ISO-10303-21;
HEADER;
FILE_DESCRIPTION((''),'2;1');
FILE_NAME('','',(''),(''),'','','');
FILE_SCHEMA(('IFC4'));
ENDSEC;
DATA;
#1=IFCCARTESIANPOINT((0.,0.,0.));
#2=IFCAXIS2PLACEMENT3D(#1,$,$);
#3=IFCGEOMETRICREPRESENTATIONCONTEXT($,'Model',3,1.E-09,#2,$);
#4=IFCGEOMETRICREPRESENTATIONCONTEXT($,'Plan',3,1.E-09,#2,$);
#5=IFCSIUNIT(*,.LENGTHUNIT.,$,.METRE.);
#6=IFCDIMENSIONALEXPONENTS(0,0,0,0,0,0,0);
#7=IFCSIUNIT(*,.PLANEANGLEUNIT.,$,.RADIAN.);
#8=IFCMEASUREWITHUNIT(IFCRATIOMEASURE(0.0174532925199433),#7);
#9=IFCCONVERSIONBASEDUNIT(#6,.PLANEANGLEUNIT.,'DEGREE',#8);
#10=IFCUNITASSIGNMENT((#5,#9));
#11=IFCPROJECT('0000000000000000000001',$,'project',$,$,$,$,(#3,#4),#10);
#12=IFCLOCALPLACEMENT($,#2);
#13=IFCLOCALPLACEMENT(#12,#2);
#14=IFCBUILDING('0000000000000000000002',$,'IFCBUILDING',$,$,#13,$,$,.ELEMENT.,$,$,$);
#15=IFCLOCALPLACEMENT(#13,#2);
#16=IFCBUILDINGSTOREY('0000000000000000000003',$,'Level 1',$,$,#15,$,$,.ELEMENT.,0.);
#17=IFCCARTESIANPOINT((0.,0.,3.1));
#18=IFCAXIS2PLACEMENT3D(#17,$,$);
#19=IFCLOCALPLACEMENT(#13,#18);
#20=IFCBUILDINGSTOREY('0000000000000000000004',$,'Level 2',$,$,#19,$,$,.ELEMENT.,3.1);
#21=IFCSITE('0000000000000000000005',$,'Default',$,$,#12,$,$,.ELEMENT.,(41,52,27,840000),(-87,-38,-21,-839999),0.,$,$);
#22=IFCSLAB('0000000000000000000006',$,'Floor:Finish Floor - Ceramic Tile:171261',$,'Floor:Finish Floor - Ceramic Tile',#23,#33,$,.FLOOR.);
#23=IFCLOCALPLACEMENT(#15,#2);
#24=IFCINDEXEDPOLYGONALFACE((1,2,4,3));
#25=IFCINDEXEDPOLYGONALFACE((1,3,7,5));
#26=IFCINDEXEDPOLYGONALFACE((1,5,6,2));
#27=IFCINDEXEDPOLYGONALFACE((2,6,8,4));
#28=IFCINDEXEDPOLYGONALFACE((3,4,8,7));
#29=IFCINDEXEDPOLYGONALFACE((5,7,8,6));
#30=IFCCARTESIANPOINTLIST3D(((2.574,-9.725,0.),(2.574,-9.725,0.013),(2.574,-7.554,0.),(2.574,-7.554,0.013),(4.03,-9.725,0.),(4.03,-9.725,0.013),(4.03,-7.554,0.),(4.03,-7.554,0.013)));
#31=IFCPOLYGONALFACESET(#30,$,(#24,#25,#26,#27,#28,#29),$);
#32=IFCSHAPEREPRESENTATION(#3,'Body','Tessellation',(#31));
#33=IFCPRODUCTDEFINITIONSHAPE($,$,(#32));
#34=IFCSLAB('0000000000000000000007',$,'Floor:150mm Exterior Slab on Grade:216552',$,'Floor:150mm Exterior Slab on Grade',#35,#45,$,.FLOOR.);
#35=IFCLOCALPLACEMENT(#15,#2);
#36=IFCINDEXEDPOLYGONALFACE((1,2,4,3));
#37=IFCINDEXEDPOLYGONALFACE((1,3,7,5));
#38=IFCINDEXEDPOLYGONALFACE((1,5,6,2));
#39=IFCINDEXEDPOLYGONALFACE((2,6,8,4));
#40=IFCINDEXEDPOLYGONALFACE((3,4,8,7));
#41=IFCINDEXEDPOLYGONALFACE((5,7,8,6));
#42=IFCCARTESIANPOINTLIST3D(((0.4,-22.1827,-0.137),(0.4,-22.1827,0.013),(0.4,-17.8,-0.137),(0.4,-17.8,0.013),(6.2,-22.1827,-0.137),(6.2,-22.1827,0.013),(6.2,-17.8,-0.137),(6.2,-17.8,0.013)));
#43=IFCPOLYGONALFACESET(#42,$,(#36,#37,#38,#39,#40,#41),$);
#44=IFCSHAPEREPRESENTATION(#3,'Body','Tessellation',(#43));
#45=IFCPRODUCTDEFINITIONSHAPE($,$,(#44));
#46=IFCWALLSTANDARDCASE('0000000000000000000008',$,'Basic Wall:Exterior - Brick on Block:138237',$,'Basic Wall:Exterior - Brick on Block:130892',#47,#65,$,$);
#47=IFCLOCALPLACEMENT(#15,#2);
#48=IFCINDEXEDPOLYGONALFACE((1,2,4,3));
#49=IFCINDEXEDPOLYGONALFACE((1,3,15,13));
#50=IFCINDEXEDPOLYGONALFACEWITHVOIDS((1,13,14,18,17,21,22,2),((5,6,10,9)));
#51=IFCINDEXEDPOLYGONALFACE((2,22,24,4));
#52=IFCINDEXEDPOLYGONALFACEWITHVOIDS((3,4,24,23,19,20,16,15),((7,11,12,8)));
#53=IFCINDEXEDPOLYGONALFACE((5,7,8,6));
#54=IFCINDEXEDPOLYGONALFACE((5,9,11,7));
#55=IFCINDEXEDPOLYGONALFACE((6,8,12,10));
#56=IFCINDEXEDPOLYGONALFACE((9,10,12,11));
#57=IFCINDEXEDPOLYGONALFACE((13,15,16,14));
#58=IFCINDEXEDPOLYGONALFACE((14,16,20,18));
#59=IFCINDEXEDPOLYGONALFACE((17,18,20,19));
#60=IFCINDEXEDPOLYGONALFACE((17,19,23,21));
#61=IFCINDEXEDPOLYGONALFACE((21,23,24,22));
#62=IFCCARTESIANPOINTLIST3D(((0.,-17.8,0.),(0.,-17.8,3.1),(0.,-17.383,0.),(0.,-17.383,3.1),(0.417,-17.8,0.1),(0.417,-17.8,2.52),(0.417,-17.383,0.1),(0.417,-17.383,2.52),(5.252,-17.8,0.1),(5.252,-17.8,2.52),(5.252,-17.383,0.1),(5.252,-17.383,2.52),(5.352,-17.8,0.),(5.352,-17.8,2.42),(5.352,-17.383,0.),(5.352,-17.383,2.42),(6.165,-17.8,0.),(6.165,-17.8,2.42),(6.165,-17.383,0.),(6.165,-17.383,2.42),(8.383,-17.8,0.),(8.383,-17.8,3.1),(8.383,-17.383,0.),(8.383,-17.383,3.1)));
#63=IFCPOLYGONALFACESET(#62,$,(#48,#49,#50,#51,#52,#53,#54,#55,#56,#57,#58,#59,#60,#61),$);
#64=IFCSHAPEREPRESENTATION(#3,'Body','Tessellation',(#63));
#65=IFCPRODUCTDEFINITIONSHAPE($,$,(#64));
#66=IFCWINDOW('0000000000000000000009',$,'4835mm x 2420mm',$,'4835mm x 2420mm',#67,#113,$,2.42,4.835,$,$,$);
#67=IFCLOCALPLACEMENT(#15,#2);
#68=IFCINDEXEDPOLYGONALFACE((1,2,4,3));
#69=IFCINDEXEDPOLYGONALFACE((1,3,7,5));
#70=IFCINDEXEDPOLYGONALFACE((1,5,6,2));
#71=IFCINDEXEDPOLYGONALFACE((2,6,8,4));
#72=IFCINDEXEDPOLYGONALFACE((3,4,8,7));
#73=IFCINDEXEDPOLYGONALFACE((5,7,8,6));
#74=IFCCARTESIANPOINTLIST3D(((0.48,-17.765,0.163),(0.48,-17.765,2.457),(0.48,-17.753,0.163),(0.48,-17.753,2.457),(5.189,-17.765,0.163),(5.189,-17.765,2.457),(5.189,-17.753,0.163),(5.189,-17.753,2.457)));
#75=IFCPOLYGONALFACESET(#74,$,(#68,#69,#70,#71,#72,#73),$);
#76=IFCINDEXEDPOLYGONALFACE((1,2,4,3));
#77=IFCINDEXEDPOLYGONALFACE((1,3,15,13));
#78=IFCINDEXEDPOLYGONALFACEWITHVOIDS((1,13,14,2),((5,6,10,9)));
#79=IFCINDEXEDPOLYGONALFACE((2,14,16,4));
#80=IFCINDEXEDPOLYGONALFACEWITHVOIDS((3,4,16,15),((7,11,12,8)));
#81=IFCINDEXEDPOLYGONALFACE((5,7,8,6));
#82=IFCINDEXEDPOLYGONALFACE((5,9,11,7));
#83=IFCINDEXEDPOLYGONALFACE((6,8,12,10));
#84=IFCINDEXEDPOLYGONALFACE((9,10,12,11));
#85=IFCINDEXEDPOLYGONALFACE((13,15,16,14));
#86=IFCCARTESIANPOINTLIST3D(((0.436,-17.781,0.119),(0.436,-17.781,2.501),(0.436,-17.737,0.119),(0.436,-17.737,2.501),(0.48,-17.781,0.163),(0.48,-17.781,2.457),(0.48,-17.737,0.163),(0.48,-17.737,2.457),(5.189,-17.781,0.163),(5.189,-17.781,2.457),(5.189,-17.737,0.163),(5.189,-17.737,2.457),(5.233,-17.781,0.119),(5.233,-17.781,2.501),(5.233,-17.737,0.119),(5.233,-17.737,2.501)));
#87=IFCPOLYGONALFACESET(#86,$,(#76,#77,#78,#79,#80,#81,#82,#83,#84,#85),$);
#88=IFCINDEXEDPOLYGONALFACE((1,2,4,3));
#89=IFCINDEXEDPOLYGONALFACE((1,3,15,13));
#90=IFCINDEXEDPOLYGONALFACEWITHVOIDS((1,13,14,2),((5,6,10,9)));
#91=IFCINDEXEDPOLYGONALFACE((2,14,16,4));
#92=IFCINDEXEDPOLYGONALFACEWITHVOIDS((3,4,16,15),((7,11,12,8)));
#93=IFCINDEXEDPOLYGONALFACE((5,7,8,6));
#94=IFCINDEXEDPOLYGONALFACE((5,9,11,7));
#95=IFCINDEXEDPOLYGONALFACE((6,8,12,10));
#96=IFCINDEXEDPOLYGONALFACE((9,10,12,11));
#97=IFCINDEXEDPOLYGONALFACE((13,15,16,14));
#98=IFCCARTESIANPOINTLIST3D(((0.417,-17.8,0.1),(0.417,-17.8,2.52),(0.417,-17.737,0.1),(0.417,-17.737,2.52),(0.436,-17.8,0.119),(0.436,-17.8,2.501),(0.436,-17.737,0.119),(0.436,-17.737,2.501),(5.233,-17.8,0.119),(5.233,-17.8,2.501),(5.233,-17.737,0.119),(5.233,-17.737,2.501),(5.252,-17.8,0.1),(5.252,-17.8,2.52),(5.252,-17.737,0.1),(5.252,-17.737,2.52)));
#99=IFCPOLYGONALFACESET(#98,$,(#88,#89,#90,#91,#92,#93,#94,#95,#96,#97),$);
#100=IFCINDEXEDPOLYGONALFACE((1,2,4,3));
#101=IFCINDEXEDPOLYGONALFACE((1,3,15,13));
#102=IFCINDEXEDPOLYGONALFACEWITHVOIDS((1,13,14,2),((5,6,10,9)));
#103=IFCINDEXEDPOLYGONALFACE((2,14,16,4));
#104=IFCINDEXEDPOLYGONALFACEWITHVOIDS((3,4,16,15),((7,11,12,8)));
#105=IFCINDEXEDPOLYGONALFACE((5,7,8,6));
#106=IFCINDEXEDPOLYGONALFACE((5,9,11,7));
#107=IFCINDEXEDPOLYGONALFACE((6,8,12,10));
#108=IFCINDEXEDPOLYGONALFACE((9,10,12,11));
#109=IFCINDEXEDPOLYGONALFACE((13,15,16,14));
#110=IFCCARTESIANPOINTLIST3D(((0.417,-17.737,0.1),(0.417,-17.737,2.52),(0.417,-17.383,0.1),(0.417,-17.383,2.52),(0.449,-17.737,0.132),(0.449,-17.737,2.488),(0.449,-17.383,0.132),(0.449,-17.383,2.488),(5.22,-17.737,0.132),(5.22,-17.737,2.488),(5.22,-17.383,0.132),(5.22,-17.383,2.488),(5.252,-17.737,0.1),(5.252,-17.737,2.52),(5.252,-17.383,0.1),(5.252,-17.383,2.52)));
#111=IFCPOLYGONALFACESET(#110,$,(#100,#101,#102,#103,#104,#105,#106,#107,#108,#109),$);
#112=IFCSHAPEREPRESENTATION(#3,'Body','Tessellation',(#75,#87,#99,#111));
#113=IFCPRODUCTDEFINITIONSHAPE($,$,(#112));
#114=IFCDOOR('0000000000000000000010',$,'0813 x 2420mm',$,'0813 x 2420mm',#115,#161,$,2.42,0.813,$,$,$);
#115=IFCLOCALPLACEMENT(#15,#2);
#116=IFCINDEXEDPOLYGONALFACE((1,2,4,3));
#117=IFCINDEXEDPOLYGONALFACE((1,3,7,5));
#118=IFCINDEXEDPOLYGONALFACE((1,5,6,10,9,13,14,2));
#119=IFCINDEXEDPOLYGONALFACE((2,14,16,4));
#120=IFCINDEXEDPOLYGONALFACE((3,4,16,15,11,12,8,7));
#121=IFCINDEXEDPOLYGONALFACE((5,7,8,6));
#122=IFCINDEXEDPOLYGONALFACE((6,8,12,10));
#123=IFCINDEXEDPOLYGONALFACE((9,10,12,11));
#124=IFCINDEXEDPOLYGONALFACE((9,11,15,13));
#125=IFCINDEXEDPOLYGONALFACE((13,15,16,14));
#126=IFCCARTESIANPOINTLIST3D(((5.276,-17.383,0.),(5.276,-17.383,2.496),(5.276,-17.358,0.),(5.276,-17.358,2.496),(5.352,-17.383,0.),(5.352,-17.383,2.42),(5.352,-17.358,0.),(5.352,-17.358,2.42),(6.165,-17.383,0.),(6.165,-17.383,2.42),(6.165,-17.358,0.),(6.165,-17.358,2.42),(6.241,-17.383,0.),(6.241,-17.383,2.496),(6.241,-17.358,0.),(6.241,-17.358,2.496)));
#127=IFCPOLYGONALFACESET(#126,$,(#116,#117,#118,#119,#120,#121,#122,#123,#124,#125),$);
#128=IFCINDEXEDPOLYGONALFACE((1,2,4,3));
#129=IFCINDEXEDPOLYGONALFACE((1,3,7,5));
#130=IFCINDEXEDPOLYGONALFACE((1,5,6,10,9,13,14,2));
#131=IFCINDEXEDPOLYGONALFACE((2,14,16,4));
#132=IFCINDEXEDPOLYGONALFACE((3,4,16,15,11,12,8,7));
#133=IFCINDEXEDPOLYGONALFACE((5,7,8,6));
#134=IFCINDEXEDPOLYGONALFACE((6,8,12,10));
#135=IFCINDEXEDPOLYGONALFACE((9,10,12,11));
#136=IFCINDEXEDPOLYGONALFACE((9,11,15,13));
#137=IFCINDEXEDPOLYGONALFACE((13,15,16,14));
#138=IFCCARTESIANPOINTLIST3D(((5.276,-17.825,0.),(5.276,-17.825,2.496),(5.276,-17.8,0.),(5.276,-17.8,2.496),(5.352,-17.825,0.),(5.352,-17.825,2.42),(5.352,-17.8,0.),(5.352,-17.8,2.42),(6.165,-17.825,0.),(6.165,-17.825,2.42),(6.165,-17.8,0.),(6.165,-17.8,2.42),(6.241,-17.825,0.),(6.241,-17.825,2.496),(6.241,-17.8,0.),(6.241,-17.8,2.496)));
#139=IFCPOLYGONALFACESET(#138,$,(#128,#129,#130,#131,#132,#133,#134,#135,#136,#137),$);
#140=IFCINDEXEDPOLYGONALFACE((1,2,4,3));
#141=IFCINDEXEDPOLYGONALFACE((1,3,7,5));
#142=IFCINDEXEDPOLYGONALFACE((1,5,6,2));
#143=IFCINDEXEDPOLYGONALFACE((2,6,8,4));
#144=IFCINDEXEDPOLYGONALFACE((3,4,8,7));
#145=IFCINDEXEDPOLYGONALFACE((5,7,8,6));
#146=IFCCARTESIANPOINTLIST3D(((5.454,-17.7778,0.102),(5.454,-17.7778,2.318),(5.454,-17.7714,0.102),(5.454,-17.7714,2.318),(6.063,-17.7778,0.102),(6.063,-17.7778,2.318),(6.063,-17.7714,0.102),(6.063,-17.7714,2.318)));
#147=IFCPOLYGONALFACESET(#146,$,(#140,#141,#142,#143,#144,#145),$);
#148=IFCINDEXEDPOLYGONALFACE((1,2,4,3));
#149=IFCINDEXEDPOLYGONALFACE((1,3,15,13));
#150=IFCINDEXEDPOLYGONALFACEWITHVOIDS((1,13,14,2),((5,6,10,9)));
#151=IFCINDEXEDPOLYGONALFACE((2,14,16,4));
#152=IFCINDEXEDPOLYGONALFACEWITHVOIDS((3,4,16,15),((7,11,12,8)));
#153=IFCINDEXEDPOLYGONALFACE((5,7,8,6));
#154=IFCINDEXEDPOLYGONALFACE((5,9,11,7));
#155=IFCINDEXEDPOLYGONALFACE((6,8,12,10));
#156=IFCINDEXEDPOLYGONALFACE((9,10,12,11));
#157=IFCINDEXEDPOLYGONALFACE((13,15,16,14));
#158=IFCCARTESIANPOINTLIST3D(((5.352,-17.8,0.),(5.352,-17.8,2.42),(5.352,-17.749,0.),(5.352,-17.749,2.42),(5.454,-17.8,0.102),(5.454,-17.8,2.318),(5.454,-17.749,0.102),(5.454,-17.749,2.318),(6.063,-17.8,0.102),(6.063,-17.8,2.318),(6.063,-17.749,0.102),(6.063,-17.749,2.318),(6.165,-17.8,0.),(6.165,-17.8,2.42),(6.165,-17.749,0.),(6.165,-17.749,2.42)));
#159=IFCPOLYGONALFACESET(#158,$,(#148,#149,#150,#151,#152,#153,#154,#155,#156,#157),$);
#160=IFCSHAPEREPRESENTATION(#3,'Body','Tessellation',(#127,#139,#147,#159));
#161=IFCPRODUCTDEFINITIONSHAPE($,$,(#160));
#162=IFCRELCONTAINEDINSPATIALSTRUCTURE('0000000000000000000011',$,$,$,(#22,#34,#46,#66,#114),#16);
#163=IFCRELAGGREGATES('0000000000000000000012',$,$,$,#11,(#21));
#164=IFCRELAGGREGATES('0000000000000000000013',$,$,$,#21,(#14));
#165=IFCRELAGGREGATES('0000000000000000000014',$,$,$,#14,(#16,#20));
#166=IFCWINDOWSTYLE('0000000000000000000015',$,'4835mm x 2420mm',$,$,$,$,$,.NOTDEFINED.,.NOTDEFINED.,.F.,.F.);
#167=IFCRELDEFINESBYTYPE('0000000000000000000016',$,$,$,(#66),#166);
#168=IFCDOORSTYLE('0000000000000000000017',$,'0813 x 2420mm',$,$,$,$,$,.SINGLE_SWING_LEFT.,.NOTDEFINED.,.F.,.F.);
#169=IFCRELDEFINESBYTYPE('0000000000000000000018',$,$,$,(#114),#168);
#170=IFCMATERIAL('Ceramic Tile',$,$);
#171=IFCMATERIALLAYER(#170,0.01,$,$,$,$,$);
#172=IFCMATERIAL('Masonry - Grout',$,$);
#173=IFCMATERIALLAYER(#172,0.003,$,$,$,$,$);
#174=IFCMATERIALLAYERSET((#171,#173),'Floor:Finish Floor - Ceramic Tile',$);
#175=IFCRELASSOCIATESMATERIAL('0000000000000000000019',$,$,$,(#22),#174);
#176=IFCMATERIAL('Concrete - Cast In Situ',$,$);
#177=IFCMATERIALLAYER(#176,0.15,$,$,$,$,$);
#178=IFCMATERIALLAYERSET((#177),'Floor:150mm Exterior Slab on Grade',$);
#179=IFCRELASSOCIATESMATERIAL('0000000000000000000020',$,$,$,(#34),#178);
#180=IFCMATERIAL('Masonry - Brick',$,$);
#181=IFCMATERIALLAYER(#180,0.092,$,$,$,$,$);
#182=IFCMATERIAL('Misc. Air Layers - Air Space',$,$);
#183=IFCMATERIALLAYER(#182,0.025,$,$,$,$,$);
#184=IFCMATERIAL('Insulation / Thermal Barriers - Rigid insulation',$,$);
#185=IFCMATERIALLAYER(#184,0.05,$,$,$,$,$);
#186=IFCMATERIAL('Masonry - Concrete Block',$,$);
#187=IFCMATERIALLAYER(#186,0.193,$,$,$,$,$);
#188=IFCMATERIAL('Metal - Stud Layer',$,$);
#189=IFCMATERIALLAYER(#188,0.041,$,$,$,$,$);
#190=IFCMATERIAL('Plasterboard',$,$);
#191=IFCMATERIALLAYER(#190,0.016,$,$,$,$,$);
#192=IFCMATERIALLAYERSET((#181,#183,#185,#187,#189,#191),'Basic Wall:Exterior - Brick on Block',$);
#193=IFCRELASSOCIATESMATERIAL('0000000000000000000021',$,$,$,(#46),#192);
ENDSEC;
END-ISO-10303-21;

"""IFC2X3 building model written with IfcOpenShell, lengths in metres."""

from ifc_helpers import new_model, entity, si_unit, converted_unit, frame, frame_2d, origin, origin_2d_with_axis, place, context, project, spatial, polyline, rectangle, outline, extrude, source, transform, mapped, material, layer, layer_set, layer_usage, type_object, type_shapes, element, fill, save


model = new_model("IFC2X3")

# Units and contexts
model_context = context("Model", 3, precision=1e-09, world=origin())
plan_context = context("Plan", 3, precision=1e-09, world=origin())
ifc_project = project(units=[si_unit("LENGTHUNIT", "METRE"), converted_unit("PLANEANGLEUNIT", "DEGREE", entity("IfcRatioMeasure", 0.0174532925199433), si_unit("PLANEANGLEUNIT", "RADIAN"), dimensions=[0, 0, 0, 0, 0, 0, 0])], contexts=[model_context, plan_context])

# Site, building, storey
site_placement = place(None, origin())
site = spatial("IfcSite", under=ifc_project, at=site_placement, Name="Default", CompositionType="ELEMENT", RefLatitude=(41, 52, 27, 840000), RefLongitude=(-87, -38, -21, -839999), RefElevation=0.0)
building_placement = place(site_placement, origin())
building = spatial("IfcBuilding", under=site, at=building_placement, Name="IFCBUILDING", CompositionType="ELEMENT")
storey_1_placement = place(building_placement, origin())
storey_1 = spatial("IfcBuildingStorey", under=building, at=storey_1_placement, Name="Level 1", CompositionType="ELEMENT", Elevation=0.0)

# Slabs
ifc_material_1 = material(Name="Ceramic Tile")
ifc_layer_1 = layer(ifc_material_1, 0.01)
ifc_material_2 = material(Name="Masonry - Grout")
ifc_layer_2 = layer(ifc_material_2, 0.003)
ifc_layer_set_1 = layer_set([ifc_layer_1, ifc_layer_2], Name="Floor:Finish Floor - Ceramic Tile")
ifc_layer_usage_1 = layer_usage(ifc_layer_set_1, "AXIS3", "POSITIVE", 0.0)
slab_1_placement = place(storey_1_placement, frame((2.574, -9.725, 0.0)))
element("IfcSlab", 1, at=slab_1_placement, inside=storey_1, material=ifc_layer_usage_1, Name="Floor:Finish Floor - Ceramic Tile:171261", ObjectType="Floor:Finish Floor - Ceramic Tile", PredefinedType="FLOOR", context=model_context, shape_type="SweptSolid", body=[
    extrude(rectangle(XDim=2.171, YDim=1.456, at=frame_2d((0.0, 0.0), x_axis=(0.0, -1.0))), frame((0.728, 1.0855, 0.013), z_axis=(0.0, 0.0, -1.0), x_axis=(-1.0, 0.0, 0.0)), (0.0, 0.0, 1.0), 0.013),
])
ifc_material_3 = material(Name="Concrete - Cast In Situ")
ifc_layer_3 = layer(ifc_material_3, 0.15)
ifc_layer_set_2 = layer_set([ifc_layer_3], Name="Floor:150mm Exterior Slab on Grade")
ifc_layer_usage_2 = layer_usage(ifc_layer_set_2, "AXIS3", "POSITIVE", 0.0)
slab_2_placement = place(storey_1_placement, frame((0.4, -22.1827, -0.137)))
element("IfcSlab", 2, at=slab_2_placement, inside=storey_1, material=ifc_layer_usage_2, Name="Floor:150mm Exterior Slab on Grade:216552", ObjectType="Floor:150mm Exterior Slab on Grade", PredefinedType="FLOOR", context=model_context, shape_type="SweptSolid", body=[
    extrude(rectangle(XDim=5.8, YDim=4.3827, at=origin_2d_with_axis()), frame((2.9, 2.1914, 0.15), z_axis=(0.0, 0.0, -1.0), x_axis=(-1.0, 0.0, 0.0)), (0.0, 0.0, 1.0), 0.15),
])

# Wall, openings, window, door
ifc_material_4 = material(Name="Masonry - Brick")
ifc_layer_4 = layer(ifc_material_4, 0.092)
ifc_material_5 = material(Name="Misc. Air Layers - Air Space")
ifc_layer_5 = layer(ifc_material_5, 0.025)
ifc_material_6 = material(Name="Insulation / Thermal Barriers - Rigid insulation")
ifc_layer_6 = layer(ifc_material_6, 0.05)
ifc_material_7 = material(Name="Masonry - Concrete Block")
ifc_layer_7 = layer(ifc_material_7, 0.193)
ifc_material_8 = material(Name="Metal - Stud Layer")
ifc_layer_8 = layer(ifc_material_8, 0.041)
ifc_material_9 = material(Name="Plasterboard")
ifc_layer_9 = layer(ifc_material_9, 0.016)
ifc_layer_set_3 = layer_set([ifc_layer_4, ifc_layer_5, ifc_layer_6, ifc_layer_7, ifc_layer_8, ifc_layer_9], Name="Basic Wall:Exterior - Brick on Block")
ifc_layer_usage_3 = layer_usage(ifc_layer_set_3, "AXIS2", "NEGATIVE", 0.2085)
wall_1_placement = place(storey_1_placement, frame((8.383, -17.5915, 0.0), z_axis=(0.0, 0.0, 1.0), x_axis=(-1.0, 0.0, 0.0)))
wall_1 = element("IfcWallStandardCase", 3, at=wall_1_placement, inside=storey_1, material=ifc_layer_usage_3, Name="Basic Wall:Exterior - Brick on Block:138237", ObjectType="Basic Wall:Exterior - Brick on Block:130892", context=model_context, shape_type="SweptSolid", body=[
    extrude(rectangle(XDim=8.383, YDim=0.417, at=frame_2d((4.1915, 0.0), x_axis=(-1.0, 0.0))), origin(), (0.0, 0.0, 1.0), 3.1),
])
opening_1_placement = place(wall_1_placement, frame((3.131, -0.2085, 0.1)))
opening_1 = element("IfcOpeningElement", 4, at=opening_1_placement, cuts=wall_1, ObjectType="Opening", context=model_context, shape_type="SweptSolid", body=[
    extrude(rectangle(XDim=2.42, YDim=4.835, at=frame_2d((1.21, 2.4175), x_axis=(1.0, 0.0))), frame((0.0, 0.0, 0.0), z_axis=(0.0, 1.0, 0.0), x_axis=(0.0, 0.0, 1.0)), (0.0, 0.0, 1.0), 0.417),
])
opening_2_placement = place(wall_1_placement, frame((2.218, -0.2085, 0.0)))
opening_2 = element("IfcOpeningElement", 5, at=opening_2_placement, cuts=wall_1, ObjectType="Opening", context=model_context, shape_type="SweptSolid", body=[
    extrude(rectangle(XDim=0.813, YDim=2.42, at=frame_2d((1.21, 0.4065), x_axis=(0.0, -1.0))), frame((0.0, 0.0, 0.0), z_axis=(0.0, 1.0, 0.0), x_axis=(0.0, 0.0, 1.0)), (0.0, 0.0, 1.0), 0.417),
])
window_style_1 = type_object("IfcWindowStyle", Name="4835mm x 2420mm", ConstructionType="NOTDEFINED", OperationType="NOTDEFINED", ParameterTakesPrecedence=False, Sizeable=False)
shared_shape_1 = source(origin(), model_context, "Body", "SweptSolid", [
    extrude(rectangle(XDim=0.012, YDim=4.709, at=origin_2d_with_axis()), frame((2.4175, 0.376, 0.063), z_axis=(0.0, 0.0, 1.0), x_axis=(0.0, -1.0, 0.0)), (0.0, 0.0, 1.0), 2.294),
    extrude(outline(polyline([(-2.3985, -1.191), (2.3985, -1.191), (2.3985, 1.191), (-2.3985, 1.191), (-2.3985, -1.191)]), holes=[polyline([(-2.3545, -1.147), (-2.3545, 1.147), (2.3545, 1.147), (2.3545, -1.147), (-2.3545, -1.147)])]), frame((2.4175, 0.354, 1.21), z_axis=(0.0, 1.0, 0.0), x_axis=(1.0, 0.0, 0.0)), (0.0, 0.0, 1.0), 0.044),
    extrude(outline(polyline([(-2.4175, -1.21), (2.4175, -1.21), (2.4175, 1.21), (-2.4175, 1.21), (-2.4175, -1.21)]), holes=[polyline([(-2.3985, -1.191), (-2.3985, 1.191), (2.3985, 1.191), (2.3985, -1.191), (-2.3985, -1.191)])]), frame((2.4175, 0.354, 1.21), z_axis=(0.0, 1.0, 0.0), x_axis=(1.0, 0.0, 0.0)), (0.0, 0.0, 1.0), 0.063),
    extrude(outline(polyline([(-2.4175, -1.21), (2.4175, -1.21), (2.4175, 1.21), (-2.4175, 1.21), (-2.4175, -1.21)]), holes=[polyline([(-2.3855, -1.178), (-2.3855, 1.178), (2.3855, 1.178), (2.3855, -1.178), (-2.3855, -1.178)])]), frame((2.4175, 0.0, 1.21), z_axis=(0.0, 1.0, 0.0), x_axis=(1.0, 0.0, 0.0)), (0.0, 0.0, 1.0), 0.354),
])
type_shapes(window_style_1, [shared_shape_1])
window_1_placement = place(opening_1_placement, origin())
window_1 = element("IfcWindow", 6, at=window_1_placement, inside=storey_1, type_object=window_style_1, Name="4835mm x 2420mm", ObjectType="4835mm x 2420mm", OverallHeight=2.42, OverallWidth=4.835, context=model_context, shape_type="MappedRepresentation", body=[
    mapped(shared_shape_1, transform((0.0, 0.0, 0.0), scale=1.0)),
])
fill(opening_1, window_1)
door_style_1 = type_object("IfcDoorStyle", Name="0813 x 2420mm", ConstructionType="NOTDEFINED", OperationType="SINGLE_SWING_LEFT", ParameterTakesPrecedence=False, Sizeable=False)
shared_shape_2 = source(origin(), model_context, "Body", "SweptSolid", [
    extrude(outline(polyline([(-0.4065, -1.191), (-0.4065, 1.229), (-0.4825, 1.229), (-0.4825, -1.267), (0.4825, -1.267), (0.4825, 1.229), (0.4065, 1.229), (0.4065, -1.191), (-0.4065, -1.191)])), frame((0.4065, 0.0, 1.229), z_axis=(0.0, 1.0, 0.0), x_axis=(1.0, 0.0, 0.0)), (0.0, 0.0, -1.0), 0.025),
    extrude(outline(polyline([(-0.4065, -1.191), (-0.4065, 1.229), (-0.4825, 1.229), (-0.4825, -1.267), (0.4825, -1.267), (0.4825, 1.229), (0.4065, 1.229), (0.4065, -1.191), (-0.4065, -1.191)])), frame((0.4065, 0.442, 1.229), z_axis=(0.0, 1.0, 0.0), x_axis=(1.0, 0.0, 0.0)), (0.0, 0.0, -1.0), 0.025),
    extrude(rectangle(XDim=0.609, YDim=0.0064, at=origin_2d_with_axis()), frame((0.4065, 0.3916, 0.102)), (0.0, 0.0, 1.0), 2.216),
    extrude(outline(polyline([(-1.21, -0.4065), (1.21, -0.4065), (1.21, 0.4065), (-1.21, 0.4065), (-1.21, -0.4065)]), holes=[polyline([(-1.108, 0.3045), (1.108, 0.3045), (1.108, -0.3045), (-1.108, -0.3045), (-1.108, 0.3045)])]), frame((0.4065, 0.417, 1.21), z_axis=(0.0, -1.0, 0.0), x_axis=(0.0, 0.0, -1.0)), (0.0, 0.0, 1.0), 0.051),
])
type_shapes(door_style_1, [shared_shape_2])
door_1_placement = place(opening_2_placement, origin())
door_1 = element("IfcDoor", 7, at=door_1_placement, inside=storey_1, type_object=door_style_1, Name="0813 x 2420mm", ObjectType="0813 x 2420mm", OverallHeight=2.42, OverallWidth=0.813, context=model_context, shape_type="MappedRepresentation", body=[
    mapped(shared_shape_2, transform((0.0, 0.0, 0.0), scale=1.0)),
])
fill(opening_2, door_1)

# Shared definitions
storey_2_placement = place(building_placement, frame((0.0, 0.0, 3.1)))
storey_2 = spatial("IfcBuildingStorey", under=building, at=storey_2_placement, Name="Level 2", CompositionType="ELEMENT", Elevation=3.1)

save(model, "model.ifc")
